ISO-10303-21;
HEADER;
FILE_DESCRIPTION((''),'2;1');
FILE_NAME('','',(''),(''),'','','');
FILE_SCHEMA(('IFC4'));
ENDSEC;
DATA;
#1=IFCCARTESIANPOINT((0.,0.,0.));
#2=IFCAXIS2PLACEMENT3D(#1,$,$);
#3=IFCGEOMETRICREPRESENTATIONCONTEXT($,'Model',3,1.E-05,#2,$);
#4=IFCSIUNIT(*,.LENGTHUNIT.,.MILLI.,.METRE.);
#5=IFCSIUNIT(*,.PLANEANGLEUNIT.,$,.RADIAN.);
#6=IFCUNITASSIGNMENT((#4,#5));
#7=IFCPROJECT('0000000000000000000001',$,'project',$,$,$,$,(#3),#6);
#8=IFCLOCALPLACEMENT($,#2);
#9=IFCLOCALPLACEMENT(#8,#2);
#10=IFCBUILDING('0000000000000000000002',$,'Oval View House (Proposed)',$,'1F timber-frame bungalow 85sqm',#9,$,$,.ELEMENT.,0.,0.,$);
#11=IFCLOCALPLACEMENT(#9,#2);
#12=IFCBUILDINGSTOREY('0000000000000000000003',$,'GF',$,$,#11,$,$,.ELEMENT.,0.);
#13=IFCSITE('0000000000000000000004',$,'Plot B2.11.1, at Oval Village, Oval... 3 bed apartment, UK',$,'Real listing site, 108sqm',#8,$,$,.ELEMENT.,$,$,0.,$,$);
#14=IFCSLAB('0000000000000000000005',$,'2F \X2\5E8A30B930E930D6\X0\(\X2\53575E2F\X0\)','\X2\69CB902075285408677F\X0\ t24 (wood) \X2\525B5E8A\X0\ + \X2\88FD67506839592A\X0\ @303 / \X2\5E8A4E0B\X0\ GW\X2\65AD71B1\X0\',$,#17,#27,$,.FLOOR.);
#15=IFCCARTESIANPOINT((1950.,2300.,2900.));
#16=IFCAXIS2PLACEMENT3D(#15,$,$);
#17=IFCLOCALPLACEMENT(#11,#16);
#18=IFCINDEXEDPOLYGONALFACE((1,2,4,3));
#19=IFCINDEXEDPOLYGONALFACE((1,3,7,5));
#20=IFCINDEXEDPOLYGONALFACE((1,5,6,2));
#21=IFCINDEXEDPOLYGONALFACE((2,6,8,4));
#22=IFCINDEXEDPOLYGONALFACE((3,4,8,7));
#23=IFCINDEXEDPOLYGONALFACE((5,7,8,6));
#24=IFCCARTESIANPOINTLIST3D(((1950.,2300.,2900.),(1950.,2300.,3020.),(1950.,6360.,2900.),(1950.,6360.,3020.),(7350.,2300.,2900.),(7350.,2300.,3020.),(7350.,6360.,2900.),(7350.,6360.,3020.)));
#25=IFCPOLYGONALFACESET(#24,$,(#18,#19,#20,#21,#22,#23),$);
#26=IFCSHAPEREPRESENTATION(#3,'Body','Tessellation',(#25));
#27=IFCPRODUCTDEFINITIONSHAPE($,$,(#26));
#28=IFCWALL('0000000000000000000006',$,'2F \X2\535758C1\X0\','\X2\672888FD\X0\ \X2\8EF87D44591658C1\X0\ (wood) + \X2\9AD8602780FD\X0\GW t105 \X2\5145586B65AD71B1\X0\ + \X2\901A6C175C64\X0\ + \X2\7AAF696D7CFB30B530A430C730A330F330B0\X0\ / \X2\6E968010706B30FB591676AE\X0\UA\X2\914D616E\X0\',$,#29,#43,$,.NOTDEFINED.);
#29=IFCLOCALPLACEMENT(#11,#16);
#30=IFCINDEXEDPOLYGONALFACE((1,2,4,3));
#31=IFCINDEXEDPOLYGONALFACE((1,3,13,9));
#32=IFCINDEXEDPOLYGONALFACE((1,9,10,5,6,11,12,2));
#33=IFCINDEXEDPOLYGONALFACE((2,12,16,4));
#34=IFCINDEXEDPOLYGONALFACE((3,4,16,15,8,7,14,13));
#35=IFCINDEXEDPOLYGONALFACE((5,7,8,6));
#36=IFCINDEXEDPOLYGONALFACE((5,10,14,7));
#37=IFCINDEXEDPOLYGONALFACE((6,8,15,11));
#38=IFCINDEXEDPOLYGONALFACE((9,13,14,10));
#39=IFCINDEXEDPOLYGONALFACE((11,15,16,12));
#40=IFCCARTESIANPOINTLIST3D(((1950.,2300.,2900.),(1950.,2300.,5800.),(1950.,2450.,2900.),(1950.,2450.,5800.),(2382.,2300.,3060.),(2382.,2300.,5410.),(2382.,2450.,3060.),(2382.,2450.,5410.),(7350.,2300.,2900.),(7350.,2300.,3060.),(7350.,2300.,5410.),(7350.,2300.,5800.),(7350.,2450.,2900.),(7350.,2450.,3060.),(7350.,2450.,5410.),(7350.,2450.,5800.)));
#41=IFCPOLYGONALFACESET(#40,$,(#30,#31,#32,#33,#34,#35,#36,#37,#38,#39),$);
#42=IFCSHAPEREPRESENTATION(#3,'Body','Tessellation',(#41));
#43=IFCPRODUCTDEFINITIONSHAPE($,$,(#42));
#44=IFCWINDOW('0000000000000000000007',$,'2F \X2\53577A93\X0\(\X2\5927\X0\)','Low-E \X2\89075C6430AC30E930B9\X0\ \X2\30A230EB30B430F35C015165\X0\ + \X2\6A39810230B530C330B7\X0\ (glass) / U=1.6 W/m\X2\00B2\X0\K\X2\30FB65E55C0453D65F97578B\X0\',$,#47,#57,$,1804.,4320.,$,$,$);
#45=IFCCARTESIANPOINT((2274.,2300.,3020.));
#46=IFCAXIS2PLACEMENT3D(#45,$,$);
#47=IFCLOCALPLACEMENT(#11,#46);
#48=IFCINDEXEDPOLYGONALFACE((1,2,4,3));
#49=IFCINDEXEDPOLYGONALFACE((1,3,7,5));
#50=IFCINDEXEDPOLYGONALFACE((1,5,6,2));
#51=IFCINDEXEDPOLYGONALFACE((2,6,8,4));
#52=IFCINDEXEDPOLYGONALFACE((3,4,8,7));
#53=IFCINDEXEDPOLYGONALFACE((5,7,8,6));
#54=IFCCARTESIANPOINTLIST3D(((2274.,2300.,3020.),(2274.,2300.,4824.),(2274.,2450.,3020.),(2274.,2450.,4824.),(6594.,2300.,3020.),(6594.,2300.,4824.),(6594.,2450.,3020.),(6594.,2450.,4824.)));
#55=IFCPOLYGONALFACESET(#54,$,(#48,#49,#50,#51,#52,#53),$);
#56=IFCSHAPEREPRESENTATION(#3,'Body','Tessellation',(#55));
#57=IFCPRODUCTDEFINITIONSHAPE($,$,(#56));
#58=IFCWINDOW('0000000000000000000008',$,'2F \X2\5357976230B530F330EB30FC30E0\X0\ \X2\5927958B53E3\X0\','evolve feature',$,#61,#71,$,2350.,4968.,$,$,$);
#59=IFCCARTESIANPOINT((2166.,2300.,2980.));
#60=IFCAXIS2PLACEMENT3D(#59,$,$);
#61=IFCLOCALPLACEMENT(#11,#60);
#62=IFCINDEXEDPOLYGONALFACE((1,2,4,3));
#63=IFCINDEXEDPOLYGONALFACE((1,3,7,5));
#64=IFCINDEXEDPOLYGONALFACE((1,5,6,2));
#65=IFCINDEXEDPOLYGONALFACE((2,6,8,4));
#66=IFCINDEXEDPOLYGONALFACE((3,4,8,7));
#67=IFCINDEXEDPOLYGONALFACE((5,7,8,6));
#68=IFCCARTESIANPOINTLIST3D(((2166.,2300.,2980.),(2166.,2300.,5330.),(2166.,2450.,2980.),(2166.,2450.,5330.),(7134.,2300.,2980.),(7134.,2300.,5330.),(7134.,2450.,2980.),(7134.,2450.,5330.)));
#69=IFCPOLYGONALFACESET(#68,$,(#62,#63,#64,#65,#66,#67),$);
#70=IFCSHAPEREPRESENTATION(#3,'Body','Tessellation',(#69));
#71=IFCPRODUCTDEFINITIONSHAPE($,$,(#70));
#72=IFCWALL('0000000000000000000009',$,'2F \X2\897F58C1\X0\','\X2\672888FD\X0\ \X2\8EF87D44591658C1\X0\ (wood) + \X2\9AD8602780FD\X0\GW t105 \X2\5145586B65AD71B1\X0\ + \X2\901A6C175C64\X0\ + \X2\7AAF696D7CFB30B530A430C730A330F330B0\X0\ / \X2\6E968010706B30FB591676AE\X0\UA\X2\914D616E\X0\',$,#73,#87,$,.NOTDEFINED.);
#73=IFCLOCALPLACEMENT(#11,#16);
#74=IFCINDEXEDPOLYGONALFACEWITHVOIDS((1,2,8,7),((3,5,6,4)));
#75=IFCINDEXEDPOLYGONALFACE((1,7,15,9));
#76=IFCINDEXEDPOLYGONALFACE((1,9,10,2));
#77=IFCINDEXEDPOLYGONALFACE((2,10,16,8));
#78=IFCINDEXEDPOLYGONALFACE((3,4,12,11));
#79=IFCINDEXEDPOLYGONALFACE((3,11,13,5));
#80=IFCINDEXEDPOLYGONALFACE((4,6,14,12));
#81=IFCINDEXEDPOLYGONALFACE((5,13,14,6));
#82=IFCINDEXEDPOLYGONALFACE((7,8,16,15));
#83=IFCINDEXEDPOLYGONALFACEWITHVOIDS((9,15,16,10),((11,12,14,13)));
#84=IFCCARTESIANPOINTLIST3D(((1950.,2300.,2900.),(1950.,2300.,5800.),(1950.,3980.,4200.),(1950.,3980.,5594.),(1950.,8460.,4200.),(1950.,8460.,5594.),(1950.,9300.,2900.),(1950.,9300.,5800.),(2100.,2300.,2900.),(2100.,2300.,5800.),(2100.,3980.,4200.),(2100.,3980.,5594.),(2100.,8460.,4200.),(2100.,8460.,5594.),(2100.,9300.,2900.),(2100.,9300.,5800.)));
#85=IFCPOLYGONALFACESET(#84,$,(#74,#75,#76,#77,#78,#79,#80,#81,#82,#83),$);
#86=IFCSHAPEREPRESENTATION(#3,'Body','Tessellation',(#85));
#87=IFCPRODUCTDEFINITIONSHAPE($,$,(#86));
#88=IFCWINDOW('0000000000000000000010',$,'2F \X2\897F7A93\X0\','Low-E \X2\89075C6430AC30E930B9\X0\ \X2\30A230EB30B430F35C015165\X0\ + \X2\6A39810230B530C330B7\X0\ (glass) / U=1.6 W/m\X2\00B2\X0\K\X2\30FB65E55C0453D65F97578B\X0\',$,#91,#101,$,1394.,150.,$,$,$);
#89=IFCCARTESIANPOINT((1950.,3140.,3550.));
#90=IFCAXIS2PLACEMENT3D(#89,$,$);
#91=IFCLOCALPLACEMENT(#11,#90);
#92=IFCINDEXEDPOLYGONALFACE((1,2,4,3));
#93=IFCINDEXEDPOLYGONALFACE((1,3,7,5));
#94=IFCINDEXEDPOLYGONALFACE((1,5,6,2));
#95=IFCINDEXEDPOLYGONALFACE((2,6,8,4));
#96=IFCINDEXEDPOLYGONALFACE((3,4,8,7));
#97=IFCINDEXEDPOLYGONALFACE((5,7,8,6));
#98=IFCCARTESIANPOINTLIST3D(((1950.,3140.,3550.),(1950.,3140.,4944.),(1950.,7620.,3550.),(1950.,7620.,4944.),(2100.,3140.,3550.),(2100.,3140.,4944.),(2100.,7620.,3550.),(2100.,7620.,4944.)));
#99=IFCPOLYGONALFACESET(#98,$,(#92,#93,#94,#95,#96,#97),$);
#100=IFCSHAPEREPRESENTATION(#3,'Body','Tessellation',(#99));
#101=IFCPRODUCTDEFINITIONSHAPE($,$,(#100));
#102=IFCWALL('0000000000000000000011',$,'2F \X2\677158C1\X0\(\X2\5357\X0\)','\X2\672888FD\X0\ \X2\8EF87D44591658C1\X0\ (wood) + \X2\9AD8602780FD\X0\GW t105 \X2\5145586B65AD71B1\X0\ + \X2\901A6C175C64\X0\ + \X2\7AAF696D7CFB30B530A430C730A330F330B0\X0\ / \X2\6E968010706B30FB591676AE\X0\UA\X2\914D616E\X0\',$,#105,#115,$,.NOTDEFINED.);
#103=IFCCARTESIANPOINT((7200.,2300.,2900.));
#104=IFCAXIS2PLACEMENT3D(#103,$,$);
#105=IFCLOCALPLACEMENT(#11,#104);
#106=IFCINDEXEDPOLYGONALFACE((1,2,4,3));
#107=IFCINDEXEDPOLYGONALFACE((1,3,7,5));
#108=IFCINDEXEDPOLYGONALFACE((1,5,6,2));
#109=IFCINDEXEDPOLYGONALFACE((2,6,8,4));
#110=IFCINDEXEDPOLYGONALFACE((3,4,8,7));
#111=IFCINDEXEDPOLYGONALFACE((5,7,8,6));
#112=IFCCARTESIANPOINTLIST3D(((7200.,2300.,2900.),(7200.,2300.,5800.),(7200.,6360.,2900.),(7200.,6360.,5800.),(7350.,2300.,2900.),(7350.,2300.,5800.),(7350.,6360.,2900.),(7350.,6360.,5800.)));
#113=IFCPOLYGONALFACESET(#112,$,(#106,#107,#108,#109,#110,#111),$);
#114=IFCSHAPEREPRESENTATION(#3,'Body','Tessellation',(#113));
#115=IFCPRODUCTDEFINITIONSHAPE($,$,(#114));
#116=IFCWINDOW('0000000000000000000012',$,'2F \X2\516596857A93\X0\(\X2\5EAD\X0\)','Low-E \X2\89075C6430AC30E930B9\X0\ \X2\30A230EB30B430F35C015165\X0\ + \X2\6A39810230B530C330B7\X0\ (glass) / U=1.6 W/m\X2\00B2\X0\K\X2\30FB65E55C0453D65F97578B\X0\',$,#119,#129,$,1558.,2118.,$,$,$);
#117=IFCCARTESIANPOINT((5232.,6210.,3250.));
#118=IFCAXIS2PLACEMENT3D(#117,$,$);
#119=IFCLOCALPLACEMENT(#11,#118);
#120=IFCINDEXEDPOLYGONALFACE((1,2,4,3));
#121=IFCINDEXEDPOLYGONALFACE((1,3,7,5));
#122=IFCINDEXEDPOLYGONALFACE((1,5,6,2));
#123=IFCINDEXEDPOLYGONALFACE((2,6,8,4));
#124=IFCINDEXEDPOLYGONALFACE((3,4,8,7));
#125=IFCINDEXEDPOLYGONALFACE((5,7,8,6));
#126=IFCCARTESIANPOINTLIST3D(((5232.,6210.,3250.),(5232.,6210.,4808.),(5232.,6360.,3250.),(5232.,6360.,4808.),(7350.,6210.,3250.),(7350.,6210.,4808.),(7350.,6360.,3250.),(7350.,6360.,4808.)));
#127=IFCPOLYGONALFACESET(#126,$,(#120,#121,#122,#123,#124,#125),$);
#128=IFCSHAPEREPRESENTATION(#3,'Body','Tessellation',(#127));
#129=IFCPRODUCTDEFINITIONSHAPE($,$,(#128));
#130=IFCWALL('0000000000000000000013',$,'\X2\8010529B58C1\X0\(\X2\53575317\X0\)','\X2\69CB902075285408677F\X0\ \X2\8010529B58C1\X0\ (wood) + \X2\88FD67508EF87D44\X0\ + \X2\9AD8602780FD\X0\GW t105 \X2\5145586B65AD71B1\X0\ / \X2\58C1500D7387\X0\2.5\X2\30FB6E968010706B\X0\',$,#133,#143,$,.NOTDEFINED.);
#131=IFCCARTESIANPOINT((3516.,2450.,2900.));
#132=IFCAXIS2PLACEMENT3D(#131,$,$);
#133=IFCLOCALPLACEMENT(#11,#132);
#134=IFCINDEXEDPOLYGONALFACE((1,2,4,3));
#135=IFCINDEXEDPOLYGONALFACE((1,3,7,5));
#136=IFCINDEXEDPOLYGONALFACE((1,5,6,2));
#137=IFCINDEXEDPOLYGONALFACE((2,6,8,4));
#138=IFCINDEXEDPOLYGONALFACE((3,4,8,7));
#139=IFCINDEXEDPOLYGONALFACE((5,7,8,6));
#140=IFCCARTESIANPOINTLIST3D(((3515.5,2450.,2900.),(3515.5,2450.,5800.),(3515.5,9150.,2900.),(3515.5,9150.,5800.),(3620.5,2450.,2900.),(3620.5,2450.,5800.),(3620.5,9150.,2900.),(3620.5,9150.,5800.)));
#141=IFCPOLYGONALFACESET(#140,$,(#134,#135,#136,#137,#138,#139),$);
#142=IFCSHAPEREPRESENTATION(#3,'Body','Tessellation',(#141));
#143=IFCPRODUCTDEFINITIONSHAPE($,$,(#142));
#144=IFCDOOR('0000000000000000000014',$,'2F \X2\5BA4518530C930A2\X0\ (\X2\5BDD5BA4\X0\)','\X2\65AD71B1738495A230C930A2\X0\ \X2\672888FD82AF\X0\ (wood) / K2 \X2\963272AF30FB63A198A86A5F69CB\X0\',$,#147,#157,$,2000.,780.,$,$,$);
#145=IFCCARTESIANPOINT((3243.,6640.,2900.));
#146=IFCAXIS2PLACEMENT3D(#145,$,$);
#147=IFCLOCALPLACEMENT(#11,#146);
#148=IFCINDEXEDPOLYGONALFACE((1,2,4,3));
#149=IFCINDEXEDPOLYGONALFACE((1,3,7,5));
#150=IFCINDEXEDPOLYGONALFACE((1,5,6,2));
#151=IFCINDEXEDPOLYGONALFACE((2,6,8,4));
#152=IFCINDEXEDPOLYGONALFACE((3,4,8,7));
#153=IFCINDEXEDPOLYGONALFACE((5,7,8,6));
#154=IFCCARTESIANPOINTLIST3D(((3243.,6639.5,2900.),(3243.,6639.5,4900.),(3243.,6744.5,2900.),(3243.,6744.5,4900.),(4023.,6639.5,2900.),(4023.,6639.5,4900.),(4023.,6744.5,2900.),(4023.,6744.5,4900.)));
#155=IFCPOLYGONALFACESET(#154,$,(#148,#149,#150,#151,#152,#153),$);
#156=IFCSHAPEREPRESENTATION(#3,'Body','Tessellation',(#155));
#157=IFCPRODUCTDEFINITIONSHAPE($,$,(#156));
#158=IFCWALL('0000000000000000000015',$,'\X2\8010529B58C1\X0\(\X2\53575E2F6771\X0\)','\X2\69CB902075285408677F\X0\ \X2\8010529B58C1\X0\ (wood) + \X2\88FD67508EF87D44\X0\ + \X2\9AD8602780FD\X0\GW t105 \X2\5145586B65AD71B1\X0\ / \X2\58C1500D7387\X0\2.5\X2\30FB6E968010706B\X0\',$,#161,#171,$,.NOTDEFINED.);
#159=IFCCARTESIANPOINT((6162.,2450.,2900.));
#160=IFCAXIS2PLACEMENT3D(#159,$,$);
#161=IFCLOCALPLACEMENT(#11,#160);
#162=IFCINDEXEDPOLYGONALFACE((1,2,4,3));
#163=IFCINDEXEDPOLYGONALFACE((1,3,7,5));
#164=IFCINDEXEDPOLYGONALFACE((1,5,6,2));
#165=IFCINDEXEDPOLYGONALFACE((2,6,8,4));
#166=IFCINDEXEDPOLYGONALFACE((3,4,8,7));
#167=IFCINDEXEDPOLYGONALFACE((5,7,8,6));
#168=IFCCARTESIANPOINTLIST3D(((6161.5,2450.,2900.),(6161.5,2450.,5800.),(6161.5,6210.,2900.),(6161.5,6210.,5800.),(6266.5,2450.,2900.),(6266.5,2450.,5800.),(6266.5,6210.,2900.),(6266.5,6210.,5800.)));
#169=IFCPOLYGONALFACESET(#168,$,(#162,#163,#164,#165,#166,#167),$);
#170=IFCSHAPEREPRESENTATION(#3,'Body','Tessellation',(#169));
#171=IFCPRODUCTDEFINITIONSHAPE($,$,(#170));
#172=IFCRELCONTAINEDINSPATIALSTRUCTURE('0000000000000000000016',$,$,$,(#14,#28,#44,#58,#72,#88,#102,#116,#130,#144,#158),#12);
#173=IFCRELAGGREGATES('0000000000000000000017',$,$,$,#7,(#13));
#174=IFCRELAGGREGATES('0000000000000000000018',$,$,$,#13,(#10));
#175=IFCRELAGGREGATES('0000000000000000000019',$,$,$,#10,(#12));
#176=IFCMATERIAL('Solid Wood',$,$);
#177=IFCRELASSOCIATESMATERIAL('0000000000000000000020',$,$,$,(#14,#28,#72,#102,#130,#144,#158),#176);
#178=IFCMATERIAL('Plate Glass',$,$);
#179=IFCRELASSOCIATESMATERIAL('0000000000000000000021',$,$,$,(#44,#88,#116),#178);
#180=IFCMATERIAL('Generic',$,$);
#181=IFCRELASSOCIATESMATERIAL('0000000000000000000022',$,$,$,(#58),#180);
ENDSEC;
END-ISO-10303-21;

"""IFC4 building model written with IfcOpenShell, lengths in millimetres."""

from ifc_helpers import new_model, si_unit, frame, frame_2d, origin, place, context, project, spatial, rectangle, extrude, material, element, fill, save


model = new_model("IFC4")

# Units and contexts
model_context = context("Model", 3, precision=1e-05, world=origin())
ifc_project = project(units=[si_unit("LENGTHUNIT", "METRE", prefix="MILLI"), si_unit("PLANEANGLEUNIT", "RADIAN")], contexts=[model_context])

# Site, building, storey
site_placement = place(None, origin())
site = spatial("IfcSite", under=ifc_project, at=site_placement, Name="Plot B2.11.1, at Oval Village, Oval... 3 bed apartment, UK", ObjectType="Real listing site, 108sqm", CompositionType="ELEMENT", RefElevation=0.0)
building_placement = place(site_placement, origin())
building = spatial("IfcBuilding", under=site, at=building_placement, Name="Oval View House (Proposed)", ObjectType="1F timber-frame bungalow 85sqm", CompositionType="ELEMENT", ElevationOfRefHeight=0.0, ElevationOfTerrain=0.0)
storey_placement = place(building_placement, origin())
storey = spatial("IfcBuildingStorey", under=building, at=storey_placement, Name="GF", CompositionType="ELEMENT", Elevation=0.0)

# Slab
ifc_material_1 = material(Name="Solid Wood")
slab_placement = place(storey_placement, frame((1950.0, 2300.0, 2900.0)))
element("IfcSlab", 1, at=slab_placement, inside=storey, material=ifc_material_1, Name="2F 床スラブ(南帯)", Description="構造用合板 t24 (wood) 剛床 + 製材根太 @303 / 床下 GW断熱", PredefinedType="FLOOR", context=model_context, shape_type="SweptSolid", body=[
    extrude(rectangle(XDim=5400.0, YDim=4060.0, at=frame_2d((2700.0, 2030.0))), frame((1950.0, 2300.0, 2900.0)), (0.0, 0.0, 1.0), 120.0),
])

# Wall, openings, windows
wall_1_placement = place(storey_placement, frame((1950.0, 2300.0, 2900.0)))
wall_1 = element("IfcWall", 2, at=wall_1_placement, inside=storey, material=ifc_material_1, Name="2F 南壁", Description="木製 軸組外壁 (wood) + 高性能GW t105 充填断熱 + 通気層 + 窯業系サイディング / 準耐火・外皮UA配慮", PredefinedType="NOTDEFINED", context=model_context, shape_type="SweptSolid", body=[
    extrude(rectangle(XDim=5400.0, YDim=150.0, at=frame_2d((2700.0, 75.0))), frame((1950.0, 2300.0, 2900.0)), (0.0, 0.0, 1.0), 2900.0),
])
opening_1_placement = place(storey_placement, frame((2274.0, 2300.0, 3020.0)))
opening_1 = element("IfcOpeningElement", 3, at=opening_1_placement, cuts=wall_1, PredefinedType="NOTDEFINED", context=model_context, shape_type="SweptSolid", body=[
    extrude(rectangle(XDim=4320.0, YDim=150.0, at=frame_2d((2160.0, 75.0))), frame((2274.0, 2300.0, 3020.0)), (0.0, 0.0, 1.0), 1804.0),
])
opening_2_placement = place(storey_placement, frame((2166.0, 2300.0, 2980.0)))
opening_2 = element("IfcOpeningElement", 4, at=opening_2_placement, cuts=wall_1, PredefinedType="NOTDEFINED", context=model_context, shape_type="SweptSolid", body=[
    extrude(rectangle(XDim=4968.0, YDim=150.0, at=frame_2d((2484.0, 75.0))), frame((2166.0, 2300.0, 2980.0)), (0.0, 0.0, 1.0), 2350.0),
])
ifc_material_2 = material(Name="Plate Glass")
window_1_placement = place(storey_placement, frame((2274.0, 2300.0, 3020.0)))
window_1 = element("IfcWindow", 5, at=window_1_placement, inside=storey, material=ifc_material_2, Name="2F 南窓(大)", Description="Low-E 複層ガラス アルゴン封入 + 樹脂サッシ (glass) / U=1.6 W/m²K・日射取得型", OverallHeight=1804.0, OverallWidth=4320.0, context=model_context, shape_type="SweptSolid", body=[
    extrude(rectangle(XDim=4320.0, YDim=150.0, at=frame_2d((2160.0, 75.0))), frame((2274.0, 2300.0, 3020.0)), (0.0, 0.0, 1.0), 1804.0),
])
fill(opening_1, window_1)
ifc_material_3 = material(Name="Generic")
window_2_placement = place(storey_placement, frame((2166.0, 2300.0, 2980.0)))
window_2 = element("IfcWindow", 6, at=window_2_placement, inside=storey, material=ifc_material_3, Name="2F 南面サンルーム 大開口", Description="evolve feature", OverallHeight=2350.0, OverallWidth=4968.0, context=model_context, shape_type="SweptSolid", body=[
    extrude(rectangle(XDim=4968.0, YDim=150.0, at=frame_2d((2484.0, 75.0))), frame((2166.0, 2300.0, 2980.0)), (0.0, 0.0, 1.0), 2350.0),
])
fill(opening_2, window_2)

# Walls, openings, windows
wall_2_placement = place(storey_placement, frame((1950.0, 2300.0, 2900.0)))
wall_2 = element("IfcWall", 7, at=wall_2_placement, inside=storey, material=ifc_material_1, Name="2F 西壁", Description="木製 軸組外壁 (wood) + 高性能GW t105 充填断熱 + 通気層 + 窯業系サイディング / 準耐火・外皮UA配慮", PredefinedType="NOTDEFINED", context=model_context, shape_type="SweptSolid", body=[
    extrude(rectangle(XDim=150.0, YDim=7000.0, at=frame_2d((75.0, 3500.0))), frame((1950.0, 2300.0, 2900.0)), (0.0, 0.0, 1.0), 2900.0),
])
opening_3_placement = place(storey_placement, frame((1950.0, 3140.0, 3550.0)))
opening_3 = element("IfcOpeningElement", 8, at=opening_3_placement, cuts=wall_2, PredefinedType="NOTDEFINED", context=model_context, shape_type="SweptSolid", body=[
    extrude(rectangle(XDim=150.0, YDim=4480.0, at=frame_2d((75.0, 2240.0))), frame((1950.0, 3140.0, 3550.0)), (0.0, 0.0, 1.0), 1394.0),
])
window_3_placement = place(storey_placement, frame((1950.0, 3140.0, 3550.0)))
window_3 = element("IfcWindow", 9, at=window_3_placement, inside=storey, material=ifc_material_2, Name="2F 西窓", Description="Low-E 複層ガラス アルゴン封入 + 樹脂サッシ (glass) / U=1.6 W/m²K・日射取得型", OverallHeight=1394.0, OverallWidth=150.0, context=model_context, shape_type="SweptSolid", body=[
    extrude(rectangle(XDim=150.0, YDim=4480.0, at=frame_2d((75.0, 2240.0))), frame((1950.0, 3140.0, 3550.0)), (0.0, 0.0, 1.0), 1394.0),
])
fill(opening_3, window_3)
wall_3_placement = place(storey_placement, frame((7200.0, 2300.0, 2900.0)))
wall_3 = element("IfcWall", 10, at=wall_3_placement, inside=storey, material=ifc_material_1, Name="2F 東壁(南)", Description="木製 軸組外壁 (wood) + 高性能GW t105 充填断熱 + 通気層 + 窯業系サイディング / 準耐火・外皮UA配慮", PredefinedType="NOTDEFINED", context=model_context, shape_type="SweptSolid", body=[
    extrude(rectangle(XDim=150.0, YDim=4060.0, at=frame_2d((75.0, 2030.0))), frame((7200.0, 2300.0, 2900.0)), (0.0, 0.0, 1.0), 2900.0),
])
opening_4_placement = place(storey_placement, frame((5232.0, 6210.0, 3250.0)))
opening_4 = element("IfcOpeningElement", 11, at=opening_4_placement, cuts=wall_3, PredefinedType="NOTDEFINED", context=model_context, shape_type="SweptSolid", body=[
    extrude(rectangle(XDim=2118.0, YDim=150.0, at=frame_2d((1059.0, 75.0))), frame((5232.0, 6210.0, 3250.0)), (0.0, 0.0, 1.0), 1558.0),
])
window_4_placement = place(storey_placement, frame((5232.0, 6210.0, 3250.0)))
window_4 = element("IfcWindow", 12, at=window_4_placement, inside=storey, material=ifc_material_2, Name="2F 入隅窓(庭)", Description="Low-E 複層ガラス アルゴン封入 + 樹脂サッシ (glass) / U=1.6 W/m²K・日射取得型", OverallHeight=1558.0, OverallWidth=2118.0, context=model_context, shape_type="SweptSolid", body=[
    extrude(rectangle(XDim=2118.0, YDim=150.0, at=frame_2d((1059.0, 75.0))), frame((5232.0, 6210.0, 3250.0)), (0.0, 0.0, 1.0), 1558.0),
])
fill(opening_4, window_4)

# Wall, opening, door
wall_4_placement = place(storey_placement, frame((3516.0, 2450.0, 2900.0)))
wall_4 = element("IfcWall", 13, at=wall_4_placement, inside=storey, material=ifc_material_1, Name="耐力壁(南北)", Description="構造用合板 耐力壁 (wood) + 製材軸組 + 高性能GW t105 充填断熱 / 壁倍率2.5・準耐火", PredefinedType="NOTDEFINED", context=model_context, shape_type="SweptSolid", body=[
    extrude(rectangle(XDim=105.0, YDim=6700.0, at=frame_2d((52.0, 3350.0))), frame((3516.0, 2450.0, 2900.0)), (0.0, 0.0, 1.0), 2900.0),
])
opening_5_placement = place(storey_placement, frame((3243.0, 6640.0, 2900.0)))
opening_5 = element("IfcOpeningElement", 14, at=opening_5_placement, cuts=wall_4, PredefinedType="NOTDEFINED", context=model_context, shape_type="SweptSolid", body=[
    extrude(rectangle(XDim=780.0, YDim=105.0, at=frame_2d((390.0, 52.0))), frame((3243.0, 6640.0, 2900.0)), (0.0, 0.0, 1.0), 2000.0),
])
door_placement = place(storey_placement, frame((3243.0, 6640.0, 2900.0)))
door = element("IfcDoor", 15, at=door_placement, inside=storey, material=ifc_material_1, Name="2F 室内ドア (寝室)", Description="断熱玄関ドア 木製芯 (wood) / K2 防犯・採風機構", OverallHeight=2000.0, OverallWidth=780.0, context=model_context, shape_type="SweptSolid", body=[
    extrude(rectangle(XDim=780.0, YDim=105.0, at=frame_2d((390.0, 52.0))), frame((3243.0, 6640.0, 2900.0)), (0.0, 0.0, 1.0), 2000.0),
])
fill(opening_5, door)

# Wall
wall_5_placement = place(storey_placement, frame((6162.0, 2450.0, 2900.0)))
element("IfcWall", 16, at=wall_5_placement, inside=storey, material=ifc_material_1, Name="耐力壁(南帯東)", Description="構造用合板 耐力壁 (wood) + 製材軸組 + 高性能GW t105 充填断熱 / 壁倍率2.5・準耐火", PredefinedType="NOTDEFINED", context=model_context, shape_type="SweptSolid", body=[
    extrude(rectangle(XDim=105.0, YDim=3760.0, at=frame_2d((52.0, 1880.0))), frame((6162.0, 2450.0, 2900.0)), (0.0, 0.0, 1.0), 2900.0),
])

save(model, "model.ifc")
